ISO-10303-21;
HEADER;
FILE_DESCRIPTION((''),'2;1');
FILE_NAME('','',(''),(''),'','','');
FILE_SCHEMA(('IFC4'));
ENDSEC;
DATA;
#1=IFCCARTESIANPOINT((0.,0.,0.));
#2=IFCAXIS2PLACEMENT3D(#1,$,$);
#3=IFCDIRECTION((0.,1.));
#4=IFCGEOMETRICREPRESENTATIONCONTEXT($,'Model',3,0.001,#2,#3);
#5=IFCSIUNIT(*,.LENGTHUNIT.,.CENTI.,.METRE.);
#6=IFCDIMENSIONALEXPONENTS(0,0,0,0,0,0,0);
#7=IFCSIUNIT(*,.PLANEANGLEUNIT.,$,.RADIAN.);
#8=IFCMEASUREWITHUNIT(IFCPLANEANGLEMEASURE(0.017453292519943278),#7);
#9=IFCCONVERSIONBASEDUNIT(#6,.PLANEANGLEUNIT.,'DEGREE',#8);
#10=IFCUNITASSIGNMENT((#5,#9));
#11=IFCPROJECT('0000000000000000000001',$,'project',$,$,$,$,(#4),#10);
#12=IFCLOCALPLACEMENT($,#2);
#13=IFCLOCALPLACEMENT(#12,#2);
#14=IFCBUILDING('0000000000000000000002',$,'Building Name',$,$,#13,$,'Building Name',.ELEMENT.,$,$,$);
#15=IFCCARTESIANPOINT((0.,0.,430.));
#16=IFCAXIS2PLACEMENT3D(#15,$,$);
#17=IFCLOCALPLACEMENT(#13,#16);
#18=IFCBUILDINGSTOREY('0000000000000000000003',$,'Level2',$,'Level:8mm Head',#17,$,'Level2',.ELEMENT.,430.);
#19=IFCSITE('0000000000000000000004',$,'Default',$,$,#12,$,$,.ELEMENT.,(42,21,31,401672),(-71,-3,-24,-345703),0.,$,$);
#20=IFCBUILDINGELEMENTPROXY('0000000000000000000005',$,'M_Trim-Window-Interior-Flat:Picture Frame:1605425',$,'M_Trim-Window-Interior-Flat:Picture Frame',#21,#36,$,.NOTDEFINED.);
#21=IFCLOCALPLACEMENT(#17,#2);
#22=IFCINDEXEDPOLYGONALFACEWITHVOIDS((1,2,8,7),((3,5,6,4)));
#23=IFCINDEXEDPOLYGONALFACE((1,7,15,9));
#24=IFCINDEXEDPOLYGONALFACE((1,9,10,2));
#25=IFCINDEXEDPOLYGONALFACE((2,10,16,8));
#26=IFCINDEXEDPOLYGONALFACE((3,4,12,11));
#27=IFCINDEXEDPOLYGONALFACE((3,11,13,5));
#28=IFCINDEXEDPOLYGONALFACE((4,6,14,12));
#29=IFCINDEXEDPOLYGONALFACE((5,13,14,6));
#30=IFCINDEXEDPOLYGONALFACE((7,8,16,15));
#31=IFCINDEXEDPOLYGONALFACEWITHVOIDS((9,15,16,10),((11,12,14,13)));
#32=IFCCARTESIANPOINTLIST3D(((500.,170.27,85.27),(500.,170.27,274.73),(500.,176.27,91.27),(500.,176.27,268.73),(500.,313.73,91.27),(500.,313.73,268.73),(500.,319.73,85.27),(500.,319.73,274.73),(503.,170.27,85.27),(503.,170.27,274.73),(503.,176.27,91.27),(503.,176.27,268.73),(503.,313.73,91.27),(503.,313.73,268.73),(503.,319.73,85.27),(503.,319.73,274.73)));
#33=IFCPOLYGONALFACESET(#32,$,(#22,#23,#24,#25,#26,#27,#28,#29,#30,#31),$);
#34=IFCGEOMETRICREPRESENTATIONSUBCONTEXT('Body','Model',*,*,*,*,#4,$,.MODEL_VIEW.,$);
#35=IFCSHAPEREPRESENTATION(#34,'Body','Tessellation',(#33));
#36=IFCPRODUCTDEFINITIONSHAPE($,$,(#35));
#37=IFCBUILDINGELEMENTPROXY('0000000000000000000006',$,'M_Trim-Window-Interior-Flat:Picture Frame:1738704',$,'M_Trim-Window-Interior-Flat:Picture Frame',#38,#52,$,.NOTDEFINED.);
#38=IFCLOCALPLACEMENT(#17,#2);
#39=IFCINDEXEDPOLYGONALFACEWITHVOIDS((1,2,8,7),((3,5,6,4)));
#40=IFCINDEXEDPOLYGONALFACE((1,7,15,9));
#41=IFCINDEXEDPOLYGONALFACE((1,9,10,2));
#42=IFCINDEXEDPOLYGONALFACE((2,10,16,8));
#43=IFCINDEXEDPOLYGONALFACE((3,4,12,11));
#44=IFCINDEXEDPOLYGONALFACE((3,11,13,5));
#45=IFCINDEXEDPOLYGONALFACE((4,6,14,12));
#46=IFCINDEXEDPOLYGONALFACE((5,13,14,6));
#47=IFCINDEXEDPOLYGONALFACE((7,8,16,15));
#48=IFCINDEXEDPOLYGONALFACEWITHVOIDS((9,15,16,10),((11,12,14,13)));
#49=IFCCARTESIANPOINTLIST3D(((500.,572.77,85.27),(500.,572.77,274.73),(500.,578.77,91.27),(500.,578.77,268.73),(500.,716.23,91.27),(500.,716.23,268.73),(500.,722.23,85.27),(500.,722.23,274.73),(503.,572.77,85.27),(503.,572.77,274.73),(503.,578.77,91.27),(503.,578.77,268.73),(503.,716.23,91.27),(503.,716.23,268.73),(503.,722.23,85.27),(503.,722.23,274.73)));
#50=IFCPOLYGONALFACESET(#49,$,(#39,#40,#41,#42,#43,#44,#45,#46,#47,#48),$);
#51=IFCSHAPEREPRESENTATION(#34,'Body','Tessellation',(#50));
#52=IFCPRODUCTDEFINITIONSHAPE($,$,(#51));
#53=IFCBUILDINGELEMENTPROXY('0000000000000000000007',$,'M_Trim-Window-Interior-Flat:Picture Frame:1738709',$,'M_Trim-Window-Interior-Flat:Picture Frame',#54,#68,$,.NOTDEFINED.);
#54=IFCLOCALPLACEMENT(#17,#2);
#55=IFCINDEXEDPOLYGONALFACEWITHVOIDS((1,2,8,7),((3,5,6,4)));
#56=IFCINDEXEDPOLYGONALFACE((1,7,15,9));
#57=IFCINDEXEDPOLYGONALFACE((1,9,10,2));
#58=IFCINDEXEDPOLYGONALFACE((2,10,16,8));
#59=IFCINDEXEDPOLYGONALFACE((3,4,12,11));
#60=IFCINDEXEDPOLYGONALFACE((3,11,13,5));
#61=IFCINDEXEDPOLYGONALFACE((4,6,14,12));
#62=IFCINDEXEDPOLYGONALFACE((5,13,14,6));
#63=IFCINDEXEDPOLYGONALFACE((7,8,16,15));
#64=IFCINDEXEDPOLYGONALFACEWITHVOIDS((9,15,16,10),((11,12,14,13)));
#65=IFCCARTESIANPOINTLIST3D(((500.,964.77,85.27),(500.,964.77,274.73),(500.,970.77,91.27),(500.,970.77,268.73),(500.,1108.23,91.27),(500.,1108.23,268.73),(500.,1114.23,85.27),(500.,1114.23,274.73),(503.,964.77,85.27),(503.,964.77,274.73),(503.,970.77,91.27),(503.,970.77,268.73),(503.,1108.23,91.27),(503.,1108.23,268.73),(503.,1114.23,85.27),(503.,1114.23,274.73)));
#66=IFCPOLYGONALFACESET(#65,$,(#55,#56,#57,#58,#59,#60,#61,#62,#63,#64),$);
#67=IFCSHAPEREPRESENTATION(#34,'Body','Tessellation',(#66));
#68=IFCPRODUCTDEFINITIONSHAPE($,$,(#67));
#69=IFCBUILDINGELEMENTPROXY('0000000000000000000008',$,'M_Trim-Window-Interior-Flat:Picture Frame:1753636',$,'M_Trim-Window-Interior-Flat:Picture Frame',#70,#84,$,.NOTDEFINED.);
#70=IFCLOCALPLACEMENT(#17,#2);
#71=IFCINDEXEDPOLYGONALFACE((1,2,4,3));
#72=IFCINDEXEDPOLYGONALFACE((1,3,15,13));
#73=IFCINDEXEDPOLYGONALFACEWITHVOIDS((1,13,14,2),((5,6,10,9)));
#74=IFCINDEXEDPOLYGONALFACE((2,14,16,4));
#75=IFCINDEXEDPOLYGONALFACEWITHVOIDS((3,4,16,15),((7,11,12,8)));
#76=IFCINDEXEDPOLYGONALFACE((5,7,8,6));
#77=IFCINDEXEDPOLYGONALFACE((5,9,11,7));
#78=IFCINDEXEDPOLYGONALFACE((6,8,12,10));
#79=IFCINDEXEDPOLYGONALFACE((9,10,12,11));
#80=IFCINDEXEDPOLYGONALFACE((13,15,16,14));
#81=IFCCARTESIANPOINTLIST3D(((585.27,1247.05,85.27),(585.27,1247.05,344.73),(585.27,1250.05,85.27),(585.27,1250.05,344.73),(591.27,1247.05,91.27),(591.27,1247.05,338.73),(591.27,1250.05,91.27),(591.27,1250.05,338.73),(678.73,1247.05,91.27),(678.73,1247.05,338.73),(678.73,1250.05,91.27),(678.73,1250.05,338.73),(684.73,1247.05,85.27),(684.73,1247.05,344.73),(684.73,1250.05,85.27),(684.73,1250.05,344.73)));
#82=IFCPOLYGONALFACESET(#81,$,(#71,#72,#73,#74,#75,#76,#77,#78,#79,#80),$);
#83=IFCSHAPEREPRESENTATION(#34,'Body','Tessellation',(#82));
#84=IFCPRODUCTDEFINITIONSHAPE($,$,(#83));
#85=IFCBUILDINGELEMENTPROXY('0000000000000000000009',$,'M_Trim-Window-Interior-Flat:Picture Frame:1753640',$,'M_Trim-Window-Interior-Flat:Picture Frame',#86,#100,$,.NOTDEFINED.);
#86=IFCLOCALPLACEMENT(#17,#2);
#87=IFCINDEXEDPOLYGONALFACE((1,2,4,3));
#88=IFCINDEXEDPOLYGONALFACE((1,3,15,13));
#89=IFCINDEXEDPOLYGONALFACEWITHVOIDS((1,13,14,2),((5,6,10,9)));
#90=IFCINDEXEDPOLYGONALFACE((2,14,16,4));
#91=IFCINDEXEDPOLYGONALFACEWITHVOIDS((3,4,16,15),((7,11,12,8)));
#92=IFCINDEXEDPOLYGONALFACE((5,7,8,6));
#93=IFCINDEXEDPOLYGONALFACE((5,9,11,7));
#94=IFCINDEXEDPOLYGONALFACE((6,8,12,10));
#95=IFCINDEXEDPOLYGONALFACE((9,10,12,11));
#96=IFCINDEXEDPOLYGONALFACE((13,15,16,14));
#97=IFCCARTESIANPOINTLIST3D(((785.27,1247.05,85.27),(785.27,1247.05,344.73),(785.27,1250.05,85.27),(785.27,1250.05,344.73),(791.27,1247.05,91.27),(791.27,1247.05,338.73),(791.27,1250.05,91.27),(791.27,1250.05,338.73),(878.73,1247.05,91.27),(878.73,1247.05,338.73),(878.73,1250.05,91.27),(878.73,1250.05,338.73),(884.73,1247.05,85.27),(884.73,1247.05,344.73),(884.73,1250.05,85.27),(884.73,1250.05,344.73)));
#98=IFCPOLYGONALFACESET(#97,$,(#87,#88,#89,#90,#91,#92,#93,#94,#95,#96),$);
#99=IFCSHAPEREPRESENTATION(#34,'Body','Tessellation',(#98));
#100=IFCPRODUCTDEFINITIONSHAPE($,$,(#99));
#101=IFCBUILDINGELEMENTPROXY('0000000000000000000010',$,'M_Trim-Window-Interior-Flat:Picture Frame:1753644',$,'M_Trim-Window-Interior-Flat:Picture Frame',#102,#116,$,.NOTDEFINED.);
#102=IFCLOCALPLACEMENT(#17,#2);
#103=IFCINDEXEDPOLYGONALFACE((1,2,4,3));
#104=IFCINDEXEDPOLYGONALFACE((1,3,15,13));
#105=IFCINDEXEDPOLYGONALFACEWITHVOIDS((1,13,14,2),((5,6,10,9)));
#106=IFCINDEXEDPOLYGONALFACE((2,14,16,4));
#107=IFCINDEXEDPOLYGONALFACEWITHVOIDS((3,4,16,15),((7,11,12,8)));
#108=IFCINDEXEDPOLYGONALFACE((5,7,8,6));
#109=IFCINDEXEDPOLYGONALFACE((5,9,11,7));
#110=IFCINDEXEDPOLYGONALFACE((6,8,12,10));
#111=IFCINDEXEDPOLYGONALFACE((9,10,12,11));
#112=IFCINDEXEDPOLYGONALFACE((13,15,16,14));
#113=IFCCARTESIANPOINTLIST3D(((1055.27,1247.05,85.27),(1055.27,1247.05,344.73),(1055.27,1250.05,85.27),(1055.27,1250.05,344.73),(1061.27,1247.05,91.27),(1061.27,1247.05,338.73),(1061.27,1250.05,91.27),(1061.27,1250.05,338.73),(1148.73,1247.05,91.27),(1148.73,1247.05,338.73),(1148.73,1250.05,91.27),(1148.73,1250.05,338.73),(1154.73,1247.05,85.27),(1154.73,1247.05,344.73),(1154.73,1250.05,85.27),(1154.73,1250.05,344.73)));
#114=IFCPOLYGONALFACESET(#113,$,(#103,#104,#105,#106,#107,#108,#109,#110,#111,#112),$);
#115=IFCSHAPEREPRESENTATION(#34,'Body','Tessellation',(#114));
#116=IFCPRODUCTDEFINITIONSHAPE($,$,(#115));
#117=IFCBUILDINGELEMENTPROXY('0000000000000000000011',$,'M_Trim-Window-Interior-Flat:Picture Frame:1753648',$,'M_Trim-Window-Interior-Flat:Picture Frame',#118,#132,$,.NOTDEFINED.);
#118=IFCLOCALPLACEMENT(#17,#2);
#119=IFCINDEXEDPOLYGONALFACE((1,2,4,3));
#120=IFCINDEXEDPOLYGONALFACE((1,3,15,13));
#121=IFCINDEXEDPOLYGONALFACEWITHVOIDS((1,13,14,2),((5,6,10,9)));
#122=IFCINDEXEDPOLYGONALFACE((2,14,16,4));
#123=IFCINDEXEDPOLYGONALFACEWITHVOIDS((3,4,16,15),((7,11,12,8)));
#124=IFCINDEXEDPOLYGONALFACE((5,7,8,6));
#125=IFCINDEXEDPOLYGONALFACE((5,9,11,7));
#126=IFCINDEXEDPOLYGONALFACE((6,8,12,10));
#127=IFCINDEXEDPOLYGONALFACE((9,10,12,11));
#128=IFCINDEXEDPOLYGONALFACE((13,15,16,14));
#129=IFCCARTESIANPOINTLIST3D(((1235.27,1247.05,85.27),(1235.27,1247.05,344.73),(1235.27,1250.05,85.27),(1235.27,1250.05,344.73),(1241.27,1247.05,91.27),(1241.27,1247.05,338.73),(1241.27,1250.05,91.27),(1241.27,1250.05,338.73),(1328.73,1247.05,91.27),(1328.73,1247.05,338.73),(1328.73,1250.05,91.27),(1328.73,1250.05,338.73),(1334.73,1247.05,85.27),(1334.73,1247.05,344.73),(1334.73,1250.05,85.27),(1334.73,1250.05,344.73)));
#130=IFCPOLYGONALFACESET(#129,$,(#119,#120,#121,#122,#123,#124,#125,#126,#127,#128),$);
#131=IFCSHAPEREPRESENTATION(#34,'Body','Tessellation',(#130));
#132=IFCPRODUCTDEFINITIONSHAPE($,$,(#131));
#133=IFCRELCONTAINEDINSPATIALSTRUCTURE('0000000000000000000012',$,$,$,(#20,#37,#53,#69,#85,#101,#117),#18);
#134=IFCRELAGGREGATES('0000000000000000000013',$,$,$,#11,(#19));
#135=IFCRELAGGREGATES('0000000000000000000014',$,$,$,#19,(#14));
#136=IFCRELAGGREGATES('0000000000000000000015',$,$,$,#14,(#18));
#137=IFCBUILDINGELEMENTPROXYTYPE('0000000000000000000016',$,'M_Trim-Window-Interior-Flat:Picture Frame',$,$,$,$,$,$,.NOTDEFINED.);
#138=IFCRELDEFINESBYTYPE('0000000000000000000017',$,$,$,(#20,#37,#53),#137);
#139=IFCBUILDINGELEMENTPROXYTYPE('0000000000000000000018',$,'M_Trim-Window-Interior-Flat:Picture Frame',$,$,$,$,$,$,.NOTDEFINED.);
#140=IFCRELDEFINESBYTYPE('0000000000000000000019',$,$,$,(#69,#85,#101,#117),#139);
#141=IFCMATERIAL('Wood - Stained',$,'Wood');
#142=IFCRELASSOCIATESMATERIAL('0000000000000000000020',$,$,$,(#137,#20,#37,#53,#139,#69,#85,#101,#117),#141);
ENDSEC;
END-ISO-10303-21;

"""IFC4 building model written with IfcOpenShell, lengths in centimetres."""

from ifc_helpers import new_model, entity, si_unit, converted_unit, direction, frame, origin, place, context, subcontext, project, spatial, indexed_curve, outline, extrude, source, transform, mapped, material, type_object, type_shapes, element, save


model = new_model("IFC4")

# Units and contexts
model_context = context("Model", 3, precision=0.001, world=origin(), true_north=direction((0.0, 1.0)))
body_context = subcontext(model_context, "Body", "Model", "MODEL_VIEW")
ifc_project = project(units=[si_unit("LENGTHUNIT", "METRE", prefix="CENTI"), converted_unit("PLANEANGLEUNIT", "DEGREE", entity("IfcPlaneAngleMeasure", 0.017453292519943278), si_unit("PLANEANGLEUNIT", "RADIAN"), dimensions=[0, 0, 0, 0, 0, 0, 0])], contexts=[model_context])

# Site, building, storey
site_placement = place(None, origin())
site = spatial("IfcSite", under=ifc_project, at=site_placement, Name="Default", CompositionType="ELEMENT", RefLatitude=(42, 21, 31, 401672), RefLongitude=(-71, -3, -24, -345703), RefElevation=0.0)
building_placement = place(site_placement, origin())
building = spatial("IfcBuilding", under=site, at=building_placement, Name="Building Name", LongName="Building Name", CompositionType="ELEMENT")
storey_placement = place(building_placement, frame((0.0, 0.0, 430.0)))
storey = spatial("IfcBuildingStorey", under=building, at=storey_placement, Name="Level2", ObjectType="Level:8mm Head", LongName="Level2", CompositionType="ELEMENT", Elevation=430.0)

# Building element proxies
ifc_material_1 = material(Name="Wood - Stained", Category="Wood")
building_element_proxy_type_1 = type_object("IfcBuildingElementProxyType", Name="M_Trim-Window-Interior-Flat:Picture Frame", PredefinedType="NOTDEFINED", material=ifc_material_1)
shared_shape_1 = source(origin(), body_context, "Body", "SweptSolid", [
    extrude(outline(indexed_curve([(-94.73, -74.73), (94.73, -74.73), (94.73, 74.73), (-94.73, 74.73), (-94.73, -74.73)], self_intersect=False), holes=[indexed_curve([(-88.73, -68.73), (-88.73, 68.73), (88.73, 68.73), (88.73, -68.73), (-88.73, -68.73)], self_intersect=False)]), frame((0.0, 90.0, 0.0), z_axis=(0.0, 0.0, 1.0), x_axis=(0.0, 1.0, 0.0)), (0.0, 0.0, 1.0), 3.0),
])
type_shapes(building_element_proxy_type_1, [shared_shape_1])
for number, where, z_axis, x_axis, name in (
    (1, (500.0, 245.0, 270.0), (1.0, 0.0, 0.0), (0.0, -1.0, 0.0), "M_Trim-Window-Interior-Flat:Picture Frame:1605425"),
    (2, (500.0, 647.5, 270.0), (1.0, 0.0, 0.0), (0.0, -1.0, 0.0), "M_Trim-Window-Interior-Flat:Picture Frame:1738704"),
    (3, (500.0, 1039.5, 270.0), (1.0, 0.0, 0.0), (0.0, -1.0, 0.0), "M_Trim-Window-Interior-Flat:Picture Frame:1738709"),
):
    element("IfcBuildingElementProxy", number, at=place(storey_placement, frame(where, z_axis=z_axis, x_axis=x_axis)), inside=storey, type_object=building_element_proxy_type_1, material=ifc_material_1, Name=name, ObjectType="M_Trim-Window-Interior-Flat:Picture Frame", PredefinedType="NOTDEFINED", context=body_context, shape_type="MappedRepresentation", body=[
        mapped(shared_shape_1, transform((0.0, 0.0, 0.0), scale=1.0)),
    ])
building_element_proxy_type_2 = type_object("IfcBuildingElementProxyType", Name="M_Trim-Window-Interior-Flat:Picture Frame", PredefinedType="NOTDEFINED", material=ifc_material_1)
shared_shape_2 = source(origin(), body_context, "Body", "SweptSolid", [
    extrude(outline(indexed_curve([(-49.73, -129.73), (49.73, -129.73), (49.73, 129.73), (-49.73, 129.73), (-49.73, -129.73)], self_intersect=False), holes=[indexed_curve([(-43.73, -123.73), (-43.73, 123.73), (43.73, 123.73), (43.73, -123.73), (-43.73, -123.73)], self_intersect=False)]), frame((0.0, -125.0, 0.0), z_axis=(0.0, 0.0, 1.0), x_axis=(-1.0, 0.0, 0.0)), (0.0, 0.0, 1.0), 3.0),
])
type_shapes(building_element_proxy_type_2, [shared_shape_2])
for number, where, z_axis, x_axis, name in (
    (4, (635.0, 1250.05, 340.0), (0.0, -1.0, 0.0), (1.0, 0.0, 0.0), "M_Trim-Window-Interior-Flat:Picture Frame:1753636"),
    (5, (835.0, 1250.05, 340.0), (0.0, -1.0, 0.0), (1.0, 0.0, 0.0), "M_Trim-Window-Interior-Flat:Picture Frame:1753640"),
    (6, (1105.0, 1250.05, 340.0), (0.0, -1.0, 0.0), (1.0, 0.0, 0.0), "M_Trim-Window-Interior-Flat:Picture Frame:1753644"),
    (7, (1285.0, 1250.05, 340.0), (0.0, -1.0, 0.0), (1.0, 0.0, 0.0), "M_Trim-Window-Interior-Flat:Picture Frame:1753648"),
):
    element("IfcBuildingElementProxy", number, at=place(storey_placement, frame(where, z_axis=z_axis, x_axis=x_axis)), inside=storey, type_object=building_element_proxy_type_2, material=ifc_material_1, Name=name, ObjectType="M_Trim-Window-Interior-Flat:Picture Frame", PredefinedType="NOTDEFINED", context=body_context, shape_type="MappedRepresentation", body=[
        mapped(shared_shape_2, transform((0.0, 0.0, 0.0), scale=1.0)),
    ])

save(model, "model.ifc")
